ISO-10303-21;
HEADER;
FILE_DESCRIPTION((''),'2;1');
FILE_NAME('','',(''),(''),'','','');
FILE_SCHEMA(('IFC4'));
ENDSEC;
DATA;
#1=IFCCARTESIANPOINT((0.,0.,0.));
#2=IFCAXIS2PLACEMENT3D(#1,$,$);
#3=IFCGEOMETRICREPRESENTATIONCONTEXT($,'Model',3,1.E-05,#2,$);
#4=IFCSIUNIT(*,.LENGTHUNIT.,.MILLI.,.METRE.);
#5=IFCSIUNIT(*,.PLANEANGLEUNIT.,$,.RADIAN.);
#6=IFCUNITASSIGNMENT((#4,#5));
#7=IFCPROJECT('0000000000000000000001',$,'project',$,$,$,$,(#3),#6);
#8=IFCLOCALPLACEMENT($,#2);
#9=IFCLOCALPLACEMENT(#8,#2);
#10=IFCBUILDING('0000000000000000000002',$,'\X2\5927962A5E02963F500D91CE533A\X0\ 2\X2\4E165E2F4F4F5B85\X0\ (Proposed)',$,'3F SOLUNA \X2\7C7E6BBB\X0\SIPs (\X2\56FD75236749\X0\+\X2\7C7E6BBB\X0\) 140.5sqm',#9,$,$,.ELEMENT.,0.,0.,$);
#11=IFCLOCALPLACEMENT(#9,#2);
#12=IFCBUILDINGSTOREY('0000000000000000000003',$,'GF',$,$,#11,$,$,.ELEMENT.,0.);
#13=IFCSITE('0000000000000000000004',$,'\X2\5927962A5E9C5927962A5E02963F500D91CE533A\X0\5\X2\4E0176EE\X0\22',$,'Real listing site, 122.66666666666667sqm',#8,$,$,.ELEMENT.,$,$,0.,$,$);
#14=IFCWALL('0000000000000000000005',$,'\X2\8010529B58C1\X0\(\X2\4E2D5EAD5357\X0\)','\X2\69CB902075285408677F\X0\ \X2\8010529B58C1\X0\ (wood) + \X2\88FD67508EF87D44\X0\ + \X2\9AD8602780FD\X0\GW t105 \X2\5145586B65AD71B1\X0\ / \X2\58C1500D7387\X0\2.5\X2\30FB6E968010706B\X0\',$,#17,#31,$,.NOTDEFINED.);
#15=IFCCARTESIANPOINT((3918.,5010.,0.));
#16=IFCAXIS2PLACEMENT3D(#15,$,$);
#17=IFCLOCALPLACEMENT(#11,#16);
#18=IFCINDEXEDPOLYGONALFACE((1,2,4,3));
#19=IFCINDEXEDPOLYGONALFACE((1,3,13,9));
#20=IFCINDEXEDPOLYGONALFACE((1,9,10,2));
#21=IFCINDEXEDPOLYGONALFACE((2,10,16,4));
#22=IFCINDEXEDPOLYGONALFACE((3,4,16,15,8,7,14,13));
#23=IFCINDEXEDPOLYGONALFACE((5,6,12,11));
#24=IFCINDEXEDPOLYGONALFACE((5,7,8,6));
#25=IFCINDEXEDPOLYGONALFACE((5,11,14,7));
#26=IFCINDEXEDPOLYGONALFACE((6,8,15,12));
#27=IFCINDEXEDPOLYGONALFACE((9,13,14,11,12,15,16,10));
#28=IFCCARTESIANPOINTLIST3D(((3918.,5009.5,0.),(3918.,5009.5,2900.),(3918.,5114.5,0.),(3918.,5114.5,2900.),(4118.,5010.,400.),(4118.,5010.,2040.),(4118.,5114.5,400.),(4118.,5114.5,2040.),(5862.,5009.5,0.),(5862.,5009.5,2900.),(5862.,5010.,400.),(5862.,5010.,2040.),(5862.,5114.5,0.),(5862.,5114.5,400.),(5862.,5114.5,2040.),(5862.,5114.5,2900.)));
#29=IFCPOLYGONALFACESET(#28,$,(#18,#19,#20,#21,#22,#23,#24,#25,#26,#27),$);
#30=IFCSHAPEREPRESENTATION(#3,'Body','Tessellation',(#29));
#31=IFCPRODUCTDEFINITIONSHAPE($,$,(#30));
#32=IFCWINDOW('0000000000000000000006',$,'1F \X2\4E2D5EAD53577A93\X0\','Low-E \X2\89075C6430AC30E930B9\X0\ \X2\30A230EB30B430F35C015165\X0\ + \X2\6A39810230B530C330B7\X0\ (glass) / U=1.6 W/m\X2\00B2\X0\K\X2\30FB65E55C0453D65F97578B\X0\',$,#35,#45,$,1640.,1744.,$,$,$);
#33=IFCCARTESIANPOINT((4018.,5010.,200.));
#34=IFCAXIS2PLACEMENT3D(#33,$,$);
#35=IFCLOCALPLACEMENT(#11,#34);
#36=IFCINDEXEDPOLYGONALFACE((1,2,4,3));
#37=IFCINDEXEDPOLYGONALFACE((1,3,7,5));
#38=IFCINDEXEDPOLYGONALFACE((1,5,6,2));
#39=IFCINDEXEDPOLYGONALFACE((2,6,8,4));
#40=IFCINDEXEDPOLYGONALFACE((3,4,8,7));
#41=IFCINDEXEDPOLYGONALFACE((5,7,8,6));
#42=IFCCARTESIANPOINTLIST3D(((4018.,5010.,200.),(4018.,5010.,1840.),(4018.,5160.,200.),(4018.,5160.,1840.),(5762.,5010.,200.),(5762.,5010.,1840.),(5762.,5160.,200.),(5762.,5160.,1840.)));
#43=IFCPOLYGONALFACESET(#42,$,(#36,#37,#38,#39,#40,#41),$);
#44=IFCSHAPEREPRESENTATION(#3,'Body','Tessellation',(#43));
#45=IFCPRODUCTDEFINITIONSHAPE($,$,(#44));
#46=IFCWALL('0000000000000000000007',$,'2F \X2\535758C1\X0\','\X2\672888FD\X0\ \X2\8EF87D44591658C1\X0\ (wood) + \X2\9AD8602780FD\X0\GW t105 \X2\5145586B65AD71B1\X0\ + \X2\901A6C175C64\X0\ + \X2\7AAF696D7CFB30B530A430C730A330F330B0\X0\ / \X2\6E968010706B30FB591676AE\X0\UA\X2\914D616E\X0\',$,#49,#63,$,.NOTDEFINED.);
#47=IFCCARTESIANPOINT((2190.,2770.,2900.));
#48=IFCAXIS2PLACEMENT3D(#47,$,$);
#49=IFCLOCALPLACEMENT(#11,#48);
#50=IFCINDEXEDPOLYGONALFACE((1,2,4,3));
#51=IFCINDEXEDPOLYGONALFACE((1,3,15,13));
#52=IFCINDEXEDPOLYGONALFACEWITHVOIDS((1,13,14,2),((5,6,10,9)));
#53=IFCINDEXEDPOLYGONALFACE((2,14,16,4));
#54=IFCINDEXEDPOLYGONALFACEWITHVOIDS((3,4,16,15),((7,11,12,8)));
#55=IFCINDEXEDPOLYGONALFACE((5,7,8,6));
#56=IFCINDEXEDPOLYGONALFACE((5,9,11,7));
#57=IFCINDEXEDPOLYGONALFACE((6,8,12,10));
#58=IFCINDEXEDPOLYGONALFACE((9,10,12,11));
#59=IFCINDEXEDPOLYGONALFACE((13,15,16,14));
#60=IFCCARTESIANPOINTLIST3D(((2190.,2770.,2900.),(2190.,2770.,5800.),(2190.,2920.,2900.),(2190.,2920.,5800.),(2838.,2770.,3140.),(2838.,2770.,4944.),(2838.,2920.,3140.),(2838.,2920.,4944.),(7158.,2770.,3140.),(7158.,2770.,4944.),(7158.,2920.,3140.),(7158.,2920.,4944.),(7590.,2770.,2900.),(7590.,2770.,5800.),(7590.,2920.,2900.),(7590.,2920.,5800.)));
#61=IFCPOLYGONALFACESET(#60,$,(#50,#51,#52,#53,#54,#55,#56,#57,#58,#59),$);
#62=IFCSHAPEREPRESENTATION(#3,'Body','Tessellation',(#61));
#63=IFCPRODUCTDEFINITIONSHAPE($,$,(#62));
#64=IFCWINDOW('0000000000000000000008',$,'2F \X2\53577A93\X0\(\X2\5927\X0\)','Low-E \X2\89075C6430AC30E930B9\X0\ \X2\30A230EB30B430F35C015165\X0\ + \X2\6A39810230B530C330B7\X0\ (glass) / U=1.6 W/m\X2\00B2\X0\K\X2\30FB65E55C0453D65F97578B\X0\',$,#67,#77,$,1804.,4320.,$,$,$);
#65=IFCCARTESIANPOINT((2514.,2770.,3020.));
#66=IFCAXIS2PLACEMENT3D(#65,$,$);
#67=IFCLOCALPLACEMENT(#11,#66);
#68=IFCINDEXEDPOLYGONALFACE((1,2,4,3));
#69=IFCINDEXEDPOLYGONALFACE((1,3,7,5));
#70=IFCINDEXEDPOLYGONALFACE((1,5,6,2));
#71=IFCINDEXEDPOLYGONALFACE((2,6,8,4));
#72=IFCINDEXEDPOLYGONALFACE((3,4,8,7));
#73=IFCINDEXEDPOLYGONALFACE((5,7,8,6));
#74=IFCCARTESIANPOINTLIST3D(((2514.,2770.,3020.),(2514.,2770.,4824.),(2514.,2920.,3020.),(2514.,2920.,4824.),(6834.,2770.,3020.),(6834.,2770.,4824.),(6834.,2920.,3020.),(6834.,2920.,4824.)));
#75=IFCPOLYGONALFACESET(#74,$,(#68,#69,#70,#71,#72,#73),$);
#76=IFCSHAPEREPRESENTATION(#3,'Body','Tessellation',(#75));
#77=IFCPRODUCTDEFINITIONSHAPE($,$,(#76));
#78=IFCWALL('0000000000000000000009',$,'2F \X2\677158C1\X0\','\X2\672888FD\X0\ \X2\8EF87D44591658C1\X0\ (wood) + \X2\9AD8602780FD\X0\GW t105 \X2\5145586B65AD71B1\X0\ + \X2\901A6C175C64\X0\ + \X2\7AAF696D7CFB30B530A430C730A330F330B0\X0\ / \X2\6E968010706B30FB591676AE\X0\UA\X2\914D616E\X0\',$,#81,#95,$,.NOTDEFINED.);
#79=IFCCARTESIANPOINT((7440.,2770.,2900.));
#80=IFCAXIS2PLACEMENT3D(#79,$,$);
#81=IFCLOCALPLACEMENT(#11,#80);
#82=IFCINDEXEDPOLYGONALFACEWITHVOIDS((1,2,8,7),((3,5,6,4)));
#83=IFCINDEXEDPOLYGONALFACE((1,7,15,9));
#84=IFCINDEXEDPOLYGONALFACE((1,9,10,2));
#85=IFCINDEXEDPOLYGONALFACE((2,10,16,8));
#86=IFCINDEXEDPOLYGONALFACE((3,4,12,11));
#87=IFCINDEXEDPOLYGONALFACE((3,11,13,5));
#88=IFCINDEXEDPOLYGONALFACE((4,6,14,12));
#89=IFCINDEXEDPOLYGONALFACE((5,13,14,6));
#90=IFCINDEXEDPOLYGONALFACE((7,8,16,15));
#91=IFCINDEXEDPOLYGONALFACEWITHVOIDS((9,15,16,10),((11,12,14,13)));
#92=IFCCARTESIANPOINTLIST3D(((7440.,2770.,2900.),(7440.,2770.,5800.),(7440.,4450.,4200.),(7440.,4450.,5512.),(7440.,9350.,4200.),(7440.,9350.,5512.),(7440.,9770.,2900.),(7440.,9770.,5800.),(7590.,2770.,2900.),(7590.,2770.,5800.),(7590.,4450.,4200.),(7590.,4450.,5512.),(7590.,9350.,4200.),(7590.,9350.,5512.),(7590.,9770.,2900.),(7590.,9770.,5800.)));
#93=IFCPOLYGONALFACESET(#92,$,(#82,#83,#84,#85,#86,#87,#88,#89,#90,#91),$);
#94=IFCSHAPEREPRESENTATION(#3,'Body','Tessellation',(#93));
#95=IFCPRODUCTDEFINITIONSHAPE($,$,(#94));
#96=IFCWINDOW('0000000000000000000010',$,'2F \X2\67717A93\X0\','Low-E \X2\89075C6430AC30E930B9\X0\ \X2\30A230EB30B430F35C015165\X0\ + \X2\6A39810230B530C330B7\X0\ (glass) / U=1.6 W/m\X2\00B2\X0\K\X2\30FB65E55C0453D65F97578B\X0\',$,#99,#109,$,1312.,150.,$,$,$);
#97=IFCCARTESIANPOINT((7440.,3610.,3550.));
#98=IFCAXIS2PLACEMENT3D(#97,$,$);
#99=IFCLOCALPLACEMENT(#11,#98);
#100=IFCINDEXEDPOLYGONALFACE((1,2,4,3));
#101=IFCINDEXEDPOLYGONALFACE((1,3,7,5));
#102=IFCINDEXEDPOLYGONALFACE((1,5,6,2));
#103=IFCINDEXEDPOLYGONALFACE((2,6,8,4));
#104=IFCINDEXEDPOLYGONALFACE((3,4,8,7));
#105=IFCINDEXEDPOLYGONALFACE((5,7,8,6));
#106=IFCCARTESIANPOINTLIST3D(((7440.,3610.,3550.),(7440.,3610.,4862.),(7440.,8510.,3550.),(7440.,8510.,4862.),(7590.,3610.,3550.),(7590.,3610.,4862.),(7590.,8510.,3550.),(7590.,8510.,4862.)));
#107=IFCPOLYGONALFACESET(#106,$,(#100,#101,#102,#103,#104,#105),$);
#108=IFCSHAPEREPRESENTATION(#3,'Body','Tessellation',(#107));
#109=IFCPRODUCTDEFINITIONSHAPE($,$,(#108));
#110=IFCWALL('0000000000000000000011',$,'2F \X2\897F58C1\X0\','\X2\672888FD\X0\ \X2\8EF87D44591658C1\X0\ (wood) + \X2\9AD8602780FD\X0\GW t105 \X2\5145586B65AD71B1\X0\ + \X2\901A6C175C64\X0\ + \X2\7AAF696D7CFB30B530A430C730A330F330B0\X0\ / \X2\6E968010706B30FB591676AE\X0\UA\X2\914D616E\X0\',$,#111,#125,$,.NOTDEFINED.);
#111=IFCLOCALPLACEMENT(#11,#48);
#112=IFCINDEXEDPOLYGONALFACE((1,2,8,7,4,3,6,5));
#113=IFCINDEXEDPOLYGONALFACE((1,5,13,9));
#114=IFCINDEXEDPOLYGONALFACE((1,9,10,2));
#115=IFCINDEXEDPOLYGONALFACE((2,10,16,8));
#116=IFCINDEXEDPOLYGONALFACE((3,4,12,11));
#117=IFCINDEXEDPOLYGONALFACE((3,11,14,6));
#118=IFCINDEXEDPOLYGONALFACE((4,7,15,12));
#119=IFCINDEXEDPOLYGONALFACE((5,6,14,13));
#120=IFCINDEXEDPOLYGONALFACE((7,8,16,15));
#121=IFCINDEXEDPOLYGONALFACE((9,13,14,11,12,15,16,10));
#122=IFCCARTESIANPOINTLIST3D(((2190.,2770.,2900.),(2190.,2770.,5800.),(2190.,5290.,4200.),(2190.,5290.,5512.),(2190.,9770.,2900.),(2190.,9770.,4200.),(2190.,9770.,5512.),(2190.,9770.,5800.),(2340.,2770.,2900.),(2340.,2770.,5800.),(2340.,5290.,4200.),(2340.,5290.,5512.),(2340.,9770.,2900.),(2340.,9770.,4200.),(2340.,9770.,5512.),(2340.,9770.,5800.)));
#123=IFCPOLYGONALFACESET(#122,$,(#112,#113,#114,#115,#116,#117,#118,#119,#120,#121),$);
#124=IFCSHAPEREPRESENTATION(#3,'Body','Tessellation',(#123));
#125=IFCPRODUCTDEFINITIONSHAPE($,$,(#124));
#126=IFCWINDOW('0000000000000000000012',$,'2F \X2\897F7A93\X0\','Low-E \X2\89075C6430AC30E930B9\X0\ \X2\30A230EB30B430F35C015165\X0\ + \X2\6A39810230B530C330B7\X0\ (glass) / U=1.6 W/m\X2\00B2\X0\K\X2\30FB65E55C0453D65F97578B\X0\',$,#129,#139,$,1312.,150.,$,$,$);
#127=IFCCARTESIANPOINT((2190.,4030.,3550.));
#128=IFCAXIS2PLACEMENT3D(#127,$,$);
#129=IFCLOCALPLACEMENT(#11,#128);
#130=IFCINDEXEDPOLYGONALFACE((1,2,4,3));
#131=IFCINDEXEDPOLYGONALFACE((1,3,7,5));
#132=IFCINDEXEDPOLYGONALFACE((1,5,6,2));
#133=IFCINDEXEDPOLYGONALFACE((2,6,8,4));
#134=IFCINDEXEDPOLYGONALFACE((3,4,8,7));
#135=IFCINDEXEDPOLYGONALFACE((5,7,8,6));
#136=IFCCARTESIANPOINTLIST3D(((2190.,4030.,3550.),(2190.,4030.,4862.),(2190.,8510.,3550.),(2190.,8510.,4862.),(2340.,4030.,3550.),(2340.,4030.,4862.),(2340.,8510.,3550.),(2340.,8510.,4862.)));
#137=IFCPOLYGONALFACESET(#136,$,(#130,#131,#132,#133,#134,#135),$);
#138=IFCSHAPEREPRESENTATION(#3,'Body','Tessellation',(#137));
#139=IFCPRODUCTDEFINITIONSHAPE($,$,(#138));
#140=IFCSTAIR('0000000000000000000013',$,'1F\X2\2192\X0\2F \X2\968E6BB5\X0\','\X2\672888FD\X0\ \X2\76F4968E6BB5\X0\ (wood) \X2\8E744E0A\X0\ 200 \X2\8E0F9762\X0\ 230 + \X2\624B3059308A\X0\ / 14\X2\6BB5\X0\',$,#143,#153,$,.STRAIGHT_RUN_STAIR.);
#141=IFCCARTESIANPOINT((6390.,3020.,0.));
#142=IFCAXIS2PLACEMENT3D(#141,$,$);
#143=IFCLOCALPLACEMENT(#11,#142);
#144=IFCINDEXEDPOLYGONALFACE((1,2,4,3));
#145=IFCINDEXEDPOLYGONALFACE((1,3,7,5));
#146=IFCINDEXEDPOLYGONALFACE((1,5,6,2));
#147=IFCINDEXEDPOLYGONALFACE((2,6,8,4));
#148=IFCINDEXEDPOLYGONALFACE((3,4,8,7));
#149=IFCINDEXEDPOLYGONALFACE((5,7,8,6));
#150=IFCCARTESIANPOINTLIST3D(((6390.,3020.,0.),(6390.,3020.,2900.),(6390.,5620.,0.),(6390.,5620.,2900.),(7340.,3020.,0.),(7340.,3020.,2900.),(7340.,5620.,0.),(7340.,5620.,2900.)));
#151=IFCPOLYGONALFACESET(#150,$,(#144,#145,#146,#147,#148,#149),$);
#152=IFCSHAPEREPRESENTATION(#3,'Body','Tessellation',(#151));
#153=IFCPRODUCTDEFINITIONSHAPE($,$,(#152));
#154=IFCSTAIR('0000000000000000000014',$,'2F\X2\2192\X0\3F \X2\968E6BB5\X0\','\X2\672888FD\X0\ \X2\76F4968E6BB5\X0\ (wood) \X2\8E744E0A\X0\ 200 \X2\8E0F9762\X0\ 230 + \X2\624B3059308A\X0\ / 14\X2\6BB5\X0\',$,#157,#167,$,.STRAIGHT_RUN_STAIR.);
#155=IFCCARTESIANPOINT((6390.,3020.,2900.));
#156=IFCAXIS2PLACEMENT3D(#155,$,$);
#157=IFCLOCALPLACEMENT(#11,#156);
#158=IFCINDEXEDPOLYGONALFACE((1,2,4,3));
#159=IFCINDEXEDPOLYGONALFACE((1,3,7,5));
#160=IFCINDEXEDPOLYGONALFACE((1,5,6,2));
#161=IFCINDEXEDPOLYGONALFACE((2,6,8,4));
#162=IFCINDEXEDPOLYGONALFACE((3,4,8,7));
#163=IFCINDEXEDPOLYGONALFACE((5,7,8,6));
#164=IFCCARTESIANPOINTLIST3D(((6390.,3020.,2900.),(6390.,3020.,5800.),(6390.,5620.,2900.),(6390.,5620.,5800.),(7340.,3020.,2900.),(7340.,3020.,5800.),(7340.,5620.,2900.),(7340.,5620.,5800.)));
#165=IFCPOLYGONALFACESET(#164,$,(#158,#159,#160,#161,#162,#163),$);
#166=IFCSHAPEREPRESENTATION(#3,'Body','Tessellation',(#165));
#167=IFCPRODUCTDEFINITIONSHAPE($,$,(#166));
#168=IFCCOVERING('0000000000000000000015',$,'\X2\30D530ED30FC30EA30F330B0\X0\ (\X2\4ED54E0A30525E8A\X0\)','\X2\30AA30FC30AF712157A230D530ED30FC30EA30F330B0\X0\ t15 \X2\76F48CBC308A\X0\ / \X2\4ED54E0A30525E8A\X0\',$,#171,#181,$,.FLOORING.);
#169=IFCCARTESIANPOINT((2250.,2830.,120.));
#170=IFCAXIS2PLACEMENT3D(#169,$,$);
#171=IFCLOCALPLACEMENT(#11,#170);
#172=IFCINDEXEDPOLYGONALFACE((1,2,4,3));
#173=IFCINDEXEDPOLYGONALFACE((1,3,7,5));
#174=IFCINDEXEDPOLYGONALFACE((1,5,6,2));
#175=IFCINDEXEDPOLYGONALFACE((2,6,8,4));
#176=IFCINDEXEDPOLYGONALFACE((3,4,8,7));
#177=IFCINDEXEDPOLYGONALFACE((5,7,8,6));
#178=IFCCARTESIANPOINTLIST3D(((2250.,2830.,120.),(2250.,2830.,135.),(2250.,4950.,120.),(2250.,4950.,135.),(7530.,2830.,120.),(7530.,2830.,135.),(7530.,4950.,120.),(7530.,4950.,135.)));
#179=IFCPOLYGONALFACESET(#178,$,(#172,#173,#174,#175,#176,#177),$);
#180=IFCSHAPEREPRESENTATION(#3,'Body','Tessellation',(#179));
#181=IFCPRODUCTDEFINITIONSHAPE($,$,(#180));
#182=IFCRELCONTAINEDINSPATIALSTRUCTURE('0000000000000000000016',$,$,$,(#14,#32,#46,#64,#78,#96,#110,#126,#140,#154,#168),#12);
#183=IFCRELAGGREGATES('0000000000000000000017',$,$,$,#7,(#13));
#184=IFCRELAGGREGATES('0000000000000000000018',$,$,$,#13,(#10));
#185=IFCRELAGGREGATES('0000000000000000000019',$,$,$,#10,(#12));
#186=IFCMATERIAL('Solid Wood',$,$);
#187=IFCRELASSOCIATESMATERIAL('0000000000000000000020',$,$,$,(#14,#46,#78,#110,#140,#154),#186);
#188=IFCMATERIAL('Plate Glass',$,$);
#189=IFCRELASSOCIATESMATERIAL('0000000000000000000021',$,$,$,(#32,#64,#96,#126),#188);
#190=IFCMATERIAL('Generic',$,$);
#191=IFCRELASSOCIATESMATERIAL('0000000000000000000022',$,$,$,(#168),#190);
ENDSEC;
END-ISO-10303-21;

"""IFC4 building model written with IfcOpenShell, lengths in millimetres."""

from ifc_helpers import new_model, si_unit, frame, frame_2d, origin, place, context, project, spatial, rectangle, extrude, material, element, fill, save


model = new_model("IFC4")

# Units and contexts
model_context = context("Model", 3, precision=1e-05, world=origin())
ifc_project = project(units=[si_unit("LENGTHUNIT", "METRE", prefix="MILLI"), si_unit("PLANEANGLEUNIT", "RADIAN")], contexts=[model_context])

# Site, building, storey
site_placement = place(None, origin())
site = spatial("IfcSite", under=ifc_project, at=site_placement, Name="大阪府大阪市阿倍野区5丁目22", ObjectType="Real listing site, 122.66666666666667sqm", CompositionType="ELEMENT", RefElevation=0.0)
building_placement = place(site_placement, origin())
building = spatial("IfcBuilding", under=site, at=building_placement, Name="大阪市阿倍野区 2世帯住宅 (Proposed)", ObjectType="3F SOLUNA 籾殻SIPs (国産杉+籾殻) 140.5sqm", CompositionType="ELEMENT", ElevationOfRefHeight=0.0, ElevationOfTerrain=0.0)
storey_placement = place(building_placement, origin())
storey = spatial("IfcBuildingStorey", under=building, at=storey_placement, Name="GF", CompositionType="ELEMENT", Elevation=0.0)

# Shared definitions
ifc_material_1 = material(Name="Solid Wood")

# Shared definitions
ifc_material_2 = material(Name="Plate Glass")

# Walls, openings, windows
wall_1_placement = place(storey_placement, frame((3918.0, 5010.0, 0.0)))
wall_1 = element("IfcWall", 1, at=wall_1_placement, inside=storey, material=ifc_material_1, Name="耐力壁(中庭南)", Description="構造用合板 耐力壁 (wood) + 製材軸組 + 高性能GW t105 充填断熱 / 壁倍率2.5・準耐火", PredefinedType="NOTDEFINED", context=model_context, shape_type="SweptSolid", body=[
    extrude(rectangle(XDim=1944.0, YDim=105.0, at=frame_2d((972.0, 52.0))), frame((3918.0, 5010.0, 0.0)), (0.0, 0.0, 1.0), 2900.0),
])
opening_1_placement = place(storey_placement, frame((4018.0, 5010.0, 200.0)))
opening_1 = element("IfcOpeningElement", 2, at=opening_1_placement, cuts=wall_1, PredefinedType="NOTDEFINED", context=model_context, shape_type="SweptSolid", body=[
    extrude(rectangle(XDim=1744.0, YDim=150.0, at=frame_2d((872.0, 75.0))), frame((4018.0, 5010.0, 200.0)), (0.0, 0.0, 1.0), 1640.0),
])
window_1_placement = place(storey_placement, frame((4018.0, 5010.0, 200.0)))
window_1 = element("IfcWindow", 3, at=window_1_placement, inside=storey, material=ifc_material_2, Name="1F 中庭南窓", Description="Low-E 複層ガラス アルゴン封入 + 樹脂サッシ (glass) / U=1.6 W/m²K・日射取得型", OverallHeight=1640.0, OverallWidth=1744.0, context=model_context, shape_type="SweptSolid", body=[
    extrude(rectangle(XDim=1744.0, YDim=150.0, at=frame_2d((872.0, 75.0))), frame((4018.0, 5010.0, 200.0)), (0.0, 0.0, 1.0), 1640.0),
])
fill(opening_1, window_1)
wall_2_placement = place(storey_placement, frame((2190.0, 2770.0, 2900.0)))
wall_2 = element("IfcWall", 4, at=wall_2_placement, inside=storey, material=ifc_material_1, Name="2F 南壁", Description="木製 軸組外壁 (wood) + 高性能GW t105 充填断熱 + 通気層 + 窯業系サイディング / 準耐火・外皮UA配慮", PredefinedType="NOTDEFINED", context=model_context, shape_type="SweptSolid", body=[
    extrude(rectangle(XDim=5400.0, YDim=150.0, at=frame_2d((2700.0, 75.0))), frame((2190.0, 2770.0, 2900.0)), (0.0, 0.0, 1.0), 2900.0),
])
opening_2_placement = place(storey_placement, frame((2514.0, 2770.0, 3020.0)))
opening_2 = element("IfcOpeningElement", 5, at=opening_2_placement, cuts=wall_2, PredefinedType="NOTDEFINED", context=model_context, shape_type="SweptSolid", body=[
    extrude(rectangle(XDim=4320.0, YDim=150.0, at=frame_2d((2160.0, 75.0))), frame((2514.0, 2770.0, 3020.0)), (0.0, 0.0, 1.0), 1804.0),
])
window_2_placement = place(storey_placement, frame((2514.0, 2770.0, 3020.0)))
window_2 = element("IfcWindow", 6, at=window_2_placement, inside=storey, material=ifc_material_2, Name="2F 南窓(大)", Description="Low-E 複層ガラス アルゴン封入 + 樹脂サッシ (glass) / U=1.6 W/m²K・日射取得型", OverallHeight=1804.0, OverallWidth=4320.0, context=model_context, shape_type="SweptSolid", body=[
    extrude(rectangle(XDim=4320.0, YDim=150.0, at=frame_2d((2160.0, 75.0))), frame((2514.0, 2770.0, 3020.0)), (0.0, 0.0, 1.0), 1804.0),
])
fill(opening_2, window_2)
wall_3_placement = place(storey_placement, frame((7440.0, 2770.0, 2900.0)))
wall_3 = element("IfcWall", 7, at=wall_3_placement, inside=storey, material=ifc_material_1, Name="2F 東壁", Description="木製 軸組外壁 (wood) + 高性能GW t105 充填断熱 + 通気層 + 窯業系サイディング / 準耐火・外皮UA配慮", PredefinedType="NOTDEFINED", context=model_context, shape_type="SweptSolid", body=[
    extrude(rectangle(XDim=150.0, YDim=7000.0, at=frame_2d((75.0, 3500.0))), frame((7440.0, 2770.0, 2900.0)), (0.0, 0.0, 1.0), 2900.0),
])
opening_3_placement = place(storey_placement, frame((7440.0, 3610.0, 3550.0)))
opening_3 = element("IfcOpeningElement", 8, at=opening_3_placement, cuts=wall_3, PredefinedType="NOTDEFINED", context=model_context, shape_type="SweptSolid", body=[
    extrude(rectangle(XDim=150.0, YDim=4900.0, at=frame_2d((75.0, 2450.0))), frame((7440.0, 3610.0, 3550.0)), (0.0, 0.0, 1.0), 1312.0),
])
window_3_placement = place(storey_placement, frame((7440.0, 3610.0, 3550.0)))
window_3 = element("IfcWindow", 9, at=window_3_placement, inside=storey, material=ifc_material_2, Name="2F 東窓", Description="Low-E 複層ガラス アルゴン封入 + 樹脂サッシ (glass) / U=1.6 W/m²K・日射取得型", OverallHeight=1312.0, OverallWidth=150.0, context=model_context, shape_type="SweptSolid", body=[
    extrude(rectangle(XDim=150.0, YDim=4900.0, at=frame_2d((75.0, 2450.0))), frame((7440.0, 3610.0, 3550.0)), (0.0, 0.0, 1.0), 1312.0),
])
fill(opening_3, window_3)
wall_4_placement = place(storey_placement, frame((2190.0, 2770.0, 2900.0)))
wall_4 = element("IfcWall", 10, at=wall_4_placement, inside=storey, material=ifc_material_1, Name="2F 西壁", Description="木製 軸組外壁 (wood) + 高性能GW t105 充填断熱 + 通気層 + 窯業系サイディング / 準耐火・外皮UA配慮", PredefinedType="NOTDEFINED", context=model_context, shape_type="SweptSolid", body=[
    extrude(rectangle(XDim=150.0, YDim=7000.0, at=frame_2d((75.0, 3500.0))), frame((2190.0, 2770.0, 2900.0)), (0.0, 0.0, 1.0), 2900.0),
])
opening_4_placement = place(storey_placement, frame((2190.0, 4030.0, 3550.0)))
opening_4 = element("IfcOpeningElement", 11, at=opening_4_placement, cuts=wall_4, PredefinedType="NOTDEFINED", context=model_context, shape_type="SweptSolid", body=[
    extrude(rectangle(XDim=150.0, YDim=4480.0, at=frame_2d((75.0, 2240.0))), frame((2190.0, 4030.0, 3550.0)), (0.0, 0.0, 1.0), 1312.0),
])
window_4_placement = place(storey_placement, frame((2190.0, 4030.0, 3550.0)))
window_4 = element("IfcWindow", 12, at=window_4_placement, inside=storey, material=ifc_material_2, Name="2F 西窓", Description="Low-E 複層ガラス アルゴン封入 + 樹脂サッシ (glass) / U=1.6 W/m²K・日射取得型", OverallHeight=1312.0, OverallWidth=150.0, context=model_context, shape_type="SweptSolid", body=[
    extrude(rectangle(XDim=150.0, YDim=4480.0, at=frame_2d((75.0, 2240.0))), frame((2190.0, 4030.0, 3550.0)), (0.0, 0.0, 1.0), 1312.0),
])
fill(opening_4, window_4)

# Stairs
stair_1_placement = place(storey_placement, frame((6390.0, 3020.0, 0.0)))
element("IfcStair", 13, at=stair_1_placement, inside=storey, material=ifc_material_1, Name="1F→2F 階段", Description="木製 直階段 (wood) 蹴上 200 踏面 230 + 手すり / 14段", PredefinedType="STRAIGHT_RUN_STAIR", context=model_context, shape_type="SweptSolid", body=[
    extrude(rectangle(XDim=950.0, YDim=2600.0, at=frame_2d((475.0, 1300.0))), frame((6390.0, 3020.0, 0.0)), (0.0, 0.0, 1.0), 2900.0),
])
stair_2_placement = place(storey_placement, frame((6390.0, 3020.0, 2900.0)))
element("IfcStair", 14, at=stair_2_placement, inside=storey, material=ifc_material_1, Name="2F→3F 階段", Description="木製 直階段 (wood) 蹴上 200 踏面 230 + 手すり / 14段", PredefinedType="STRAIGHT_RUN_STAIR", context=model_context, shape_type="SweptSolid", body=[
    extrude(rectangle(XDim=950.0, YDim=2600.0, at=frame_2d((475.0, 1300.0))), frame((6390.0, 3020.0, 2900.0)), (0.0, 0.0, 1.0), 2900.0),
])

# Covering
ifc_material_3 = material(Name="Generic")
covering_placement = place(storey_placement, frame((2250.0, 2830.0, 120.0)))
element("IfcCovering", 15, at=covering_placement, inside=storey, material=ifc_material_3, Name="フローリング (仕上げ床)", Description="オーク無垢フローリング t15 直貼り / 仕上げ床", PredefinedType="FLOORING", context=model_context, shape_type="SweptSolid", body=[
    extrude(rectangle(XDim=5280.0, YDim=2120.0, at=frame_2d((2640.0, 1060.0))), frame((2250.0, 2830.0, 120.0)), (0.0, 0.0, 1.0), 15.0),
])

save(model, "model.ifc")
